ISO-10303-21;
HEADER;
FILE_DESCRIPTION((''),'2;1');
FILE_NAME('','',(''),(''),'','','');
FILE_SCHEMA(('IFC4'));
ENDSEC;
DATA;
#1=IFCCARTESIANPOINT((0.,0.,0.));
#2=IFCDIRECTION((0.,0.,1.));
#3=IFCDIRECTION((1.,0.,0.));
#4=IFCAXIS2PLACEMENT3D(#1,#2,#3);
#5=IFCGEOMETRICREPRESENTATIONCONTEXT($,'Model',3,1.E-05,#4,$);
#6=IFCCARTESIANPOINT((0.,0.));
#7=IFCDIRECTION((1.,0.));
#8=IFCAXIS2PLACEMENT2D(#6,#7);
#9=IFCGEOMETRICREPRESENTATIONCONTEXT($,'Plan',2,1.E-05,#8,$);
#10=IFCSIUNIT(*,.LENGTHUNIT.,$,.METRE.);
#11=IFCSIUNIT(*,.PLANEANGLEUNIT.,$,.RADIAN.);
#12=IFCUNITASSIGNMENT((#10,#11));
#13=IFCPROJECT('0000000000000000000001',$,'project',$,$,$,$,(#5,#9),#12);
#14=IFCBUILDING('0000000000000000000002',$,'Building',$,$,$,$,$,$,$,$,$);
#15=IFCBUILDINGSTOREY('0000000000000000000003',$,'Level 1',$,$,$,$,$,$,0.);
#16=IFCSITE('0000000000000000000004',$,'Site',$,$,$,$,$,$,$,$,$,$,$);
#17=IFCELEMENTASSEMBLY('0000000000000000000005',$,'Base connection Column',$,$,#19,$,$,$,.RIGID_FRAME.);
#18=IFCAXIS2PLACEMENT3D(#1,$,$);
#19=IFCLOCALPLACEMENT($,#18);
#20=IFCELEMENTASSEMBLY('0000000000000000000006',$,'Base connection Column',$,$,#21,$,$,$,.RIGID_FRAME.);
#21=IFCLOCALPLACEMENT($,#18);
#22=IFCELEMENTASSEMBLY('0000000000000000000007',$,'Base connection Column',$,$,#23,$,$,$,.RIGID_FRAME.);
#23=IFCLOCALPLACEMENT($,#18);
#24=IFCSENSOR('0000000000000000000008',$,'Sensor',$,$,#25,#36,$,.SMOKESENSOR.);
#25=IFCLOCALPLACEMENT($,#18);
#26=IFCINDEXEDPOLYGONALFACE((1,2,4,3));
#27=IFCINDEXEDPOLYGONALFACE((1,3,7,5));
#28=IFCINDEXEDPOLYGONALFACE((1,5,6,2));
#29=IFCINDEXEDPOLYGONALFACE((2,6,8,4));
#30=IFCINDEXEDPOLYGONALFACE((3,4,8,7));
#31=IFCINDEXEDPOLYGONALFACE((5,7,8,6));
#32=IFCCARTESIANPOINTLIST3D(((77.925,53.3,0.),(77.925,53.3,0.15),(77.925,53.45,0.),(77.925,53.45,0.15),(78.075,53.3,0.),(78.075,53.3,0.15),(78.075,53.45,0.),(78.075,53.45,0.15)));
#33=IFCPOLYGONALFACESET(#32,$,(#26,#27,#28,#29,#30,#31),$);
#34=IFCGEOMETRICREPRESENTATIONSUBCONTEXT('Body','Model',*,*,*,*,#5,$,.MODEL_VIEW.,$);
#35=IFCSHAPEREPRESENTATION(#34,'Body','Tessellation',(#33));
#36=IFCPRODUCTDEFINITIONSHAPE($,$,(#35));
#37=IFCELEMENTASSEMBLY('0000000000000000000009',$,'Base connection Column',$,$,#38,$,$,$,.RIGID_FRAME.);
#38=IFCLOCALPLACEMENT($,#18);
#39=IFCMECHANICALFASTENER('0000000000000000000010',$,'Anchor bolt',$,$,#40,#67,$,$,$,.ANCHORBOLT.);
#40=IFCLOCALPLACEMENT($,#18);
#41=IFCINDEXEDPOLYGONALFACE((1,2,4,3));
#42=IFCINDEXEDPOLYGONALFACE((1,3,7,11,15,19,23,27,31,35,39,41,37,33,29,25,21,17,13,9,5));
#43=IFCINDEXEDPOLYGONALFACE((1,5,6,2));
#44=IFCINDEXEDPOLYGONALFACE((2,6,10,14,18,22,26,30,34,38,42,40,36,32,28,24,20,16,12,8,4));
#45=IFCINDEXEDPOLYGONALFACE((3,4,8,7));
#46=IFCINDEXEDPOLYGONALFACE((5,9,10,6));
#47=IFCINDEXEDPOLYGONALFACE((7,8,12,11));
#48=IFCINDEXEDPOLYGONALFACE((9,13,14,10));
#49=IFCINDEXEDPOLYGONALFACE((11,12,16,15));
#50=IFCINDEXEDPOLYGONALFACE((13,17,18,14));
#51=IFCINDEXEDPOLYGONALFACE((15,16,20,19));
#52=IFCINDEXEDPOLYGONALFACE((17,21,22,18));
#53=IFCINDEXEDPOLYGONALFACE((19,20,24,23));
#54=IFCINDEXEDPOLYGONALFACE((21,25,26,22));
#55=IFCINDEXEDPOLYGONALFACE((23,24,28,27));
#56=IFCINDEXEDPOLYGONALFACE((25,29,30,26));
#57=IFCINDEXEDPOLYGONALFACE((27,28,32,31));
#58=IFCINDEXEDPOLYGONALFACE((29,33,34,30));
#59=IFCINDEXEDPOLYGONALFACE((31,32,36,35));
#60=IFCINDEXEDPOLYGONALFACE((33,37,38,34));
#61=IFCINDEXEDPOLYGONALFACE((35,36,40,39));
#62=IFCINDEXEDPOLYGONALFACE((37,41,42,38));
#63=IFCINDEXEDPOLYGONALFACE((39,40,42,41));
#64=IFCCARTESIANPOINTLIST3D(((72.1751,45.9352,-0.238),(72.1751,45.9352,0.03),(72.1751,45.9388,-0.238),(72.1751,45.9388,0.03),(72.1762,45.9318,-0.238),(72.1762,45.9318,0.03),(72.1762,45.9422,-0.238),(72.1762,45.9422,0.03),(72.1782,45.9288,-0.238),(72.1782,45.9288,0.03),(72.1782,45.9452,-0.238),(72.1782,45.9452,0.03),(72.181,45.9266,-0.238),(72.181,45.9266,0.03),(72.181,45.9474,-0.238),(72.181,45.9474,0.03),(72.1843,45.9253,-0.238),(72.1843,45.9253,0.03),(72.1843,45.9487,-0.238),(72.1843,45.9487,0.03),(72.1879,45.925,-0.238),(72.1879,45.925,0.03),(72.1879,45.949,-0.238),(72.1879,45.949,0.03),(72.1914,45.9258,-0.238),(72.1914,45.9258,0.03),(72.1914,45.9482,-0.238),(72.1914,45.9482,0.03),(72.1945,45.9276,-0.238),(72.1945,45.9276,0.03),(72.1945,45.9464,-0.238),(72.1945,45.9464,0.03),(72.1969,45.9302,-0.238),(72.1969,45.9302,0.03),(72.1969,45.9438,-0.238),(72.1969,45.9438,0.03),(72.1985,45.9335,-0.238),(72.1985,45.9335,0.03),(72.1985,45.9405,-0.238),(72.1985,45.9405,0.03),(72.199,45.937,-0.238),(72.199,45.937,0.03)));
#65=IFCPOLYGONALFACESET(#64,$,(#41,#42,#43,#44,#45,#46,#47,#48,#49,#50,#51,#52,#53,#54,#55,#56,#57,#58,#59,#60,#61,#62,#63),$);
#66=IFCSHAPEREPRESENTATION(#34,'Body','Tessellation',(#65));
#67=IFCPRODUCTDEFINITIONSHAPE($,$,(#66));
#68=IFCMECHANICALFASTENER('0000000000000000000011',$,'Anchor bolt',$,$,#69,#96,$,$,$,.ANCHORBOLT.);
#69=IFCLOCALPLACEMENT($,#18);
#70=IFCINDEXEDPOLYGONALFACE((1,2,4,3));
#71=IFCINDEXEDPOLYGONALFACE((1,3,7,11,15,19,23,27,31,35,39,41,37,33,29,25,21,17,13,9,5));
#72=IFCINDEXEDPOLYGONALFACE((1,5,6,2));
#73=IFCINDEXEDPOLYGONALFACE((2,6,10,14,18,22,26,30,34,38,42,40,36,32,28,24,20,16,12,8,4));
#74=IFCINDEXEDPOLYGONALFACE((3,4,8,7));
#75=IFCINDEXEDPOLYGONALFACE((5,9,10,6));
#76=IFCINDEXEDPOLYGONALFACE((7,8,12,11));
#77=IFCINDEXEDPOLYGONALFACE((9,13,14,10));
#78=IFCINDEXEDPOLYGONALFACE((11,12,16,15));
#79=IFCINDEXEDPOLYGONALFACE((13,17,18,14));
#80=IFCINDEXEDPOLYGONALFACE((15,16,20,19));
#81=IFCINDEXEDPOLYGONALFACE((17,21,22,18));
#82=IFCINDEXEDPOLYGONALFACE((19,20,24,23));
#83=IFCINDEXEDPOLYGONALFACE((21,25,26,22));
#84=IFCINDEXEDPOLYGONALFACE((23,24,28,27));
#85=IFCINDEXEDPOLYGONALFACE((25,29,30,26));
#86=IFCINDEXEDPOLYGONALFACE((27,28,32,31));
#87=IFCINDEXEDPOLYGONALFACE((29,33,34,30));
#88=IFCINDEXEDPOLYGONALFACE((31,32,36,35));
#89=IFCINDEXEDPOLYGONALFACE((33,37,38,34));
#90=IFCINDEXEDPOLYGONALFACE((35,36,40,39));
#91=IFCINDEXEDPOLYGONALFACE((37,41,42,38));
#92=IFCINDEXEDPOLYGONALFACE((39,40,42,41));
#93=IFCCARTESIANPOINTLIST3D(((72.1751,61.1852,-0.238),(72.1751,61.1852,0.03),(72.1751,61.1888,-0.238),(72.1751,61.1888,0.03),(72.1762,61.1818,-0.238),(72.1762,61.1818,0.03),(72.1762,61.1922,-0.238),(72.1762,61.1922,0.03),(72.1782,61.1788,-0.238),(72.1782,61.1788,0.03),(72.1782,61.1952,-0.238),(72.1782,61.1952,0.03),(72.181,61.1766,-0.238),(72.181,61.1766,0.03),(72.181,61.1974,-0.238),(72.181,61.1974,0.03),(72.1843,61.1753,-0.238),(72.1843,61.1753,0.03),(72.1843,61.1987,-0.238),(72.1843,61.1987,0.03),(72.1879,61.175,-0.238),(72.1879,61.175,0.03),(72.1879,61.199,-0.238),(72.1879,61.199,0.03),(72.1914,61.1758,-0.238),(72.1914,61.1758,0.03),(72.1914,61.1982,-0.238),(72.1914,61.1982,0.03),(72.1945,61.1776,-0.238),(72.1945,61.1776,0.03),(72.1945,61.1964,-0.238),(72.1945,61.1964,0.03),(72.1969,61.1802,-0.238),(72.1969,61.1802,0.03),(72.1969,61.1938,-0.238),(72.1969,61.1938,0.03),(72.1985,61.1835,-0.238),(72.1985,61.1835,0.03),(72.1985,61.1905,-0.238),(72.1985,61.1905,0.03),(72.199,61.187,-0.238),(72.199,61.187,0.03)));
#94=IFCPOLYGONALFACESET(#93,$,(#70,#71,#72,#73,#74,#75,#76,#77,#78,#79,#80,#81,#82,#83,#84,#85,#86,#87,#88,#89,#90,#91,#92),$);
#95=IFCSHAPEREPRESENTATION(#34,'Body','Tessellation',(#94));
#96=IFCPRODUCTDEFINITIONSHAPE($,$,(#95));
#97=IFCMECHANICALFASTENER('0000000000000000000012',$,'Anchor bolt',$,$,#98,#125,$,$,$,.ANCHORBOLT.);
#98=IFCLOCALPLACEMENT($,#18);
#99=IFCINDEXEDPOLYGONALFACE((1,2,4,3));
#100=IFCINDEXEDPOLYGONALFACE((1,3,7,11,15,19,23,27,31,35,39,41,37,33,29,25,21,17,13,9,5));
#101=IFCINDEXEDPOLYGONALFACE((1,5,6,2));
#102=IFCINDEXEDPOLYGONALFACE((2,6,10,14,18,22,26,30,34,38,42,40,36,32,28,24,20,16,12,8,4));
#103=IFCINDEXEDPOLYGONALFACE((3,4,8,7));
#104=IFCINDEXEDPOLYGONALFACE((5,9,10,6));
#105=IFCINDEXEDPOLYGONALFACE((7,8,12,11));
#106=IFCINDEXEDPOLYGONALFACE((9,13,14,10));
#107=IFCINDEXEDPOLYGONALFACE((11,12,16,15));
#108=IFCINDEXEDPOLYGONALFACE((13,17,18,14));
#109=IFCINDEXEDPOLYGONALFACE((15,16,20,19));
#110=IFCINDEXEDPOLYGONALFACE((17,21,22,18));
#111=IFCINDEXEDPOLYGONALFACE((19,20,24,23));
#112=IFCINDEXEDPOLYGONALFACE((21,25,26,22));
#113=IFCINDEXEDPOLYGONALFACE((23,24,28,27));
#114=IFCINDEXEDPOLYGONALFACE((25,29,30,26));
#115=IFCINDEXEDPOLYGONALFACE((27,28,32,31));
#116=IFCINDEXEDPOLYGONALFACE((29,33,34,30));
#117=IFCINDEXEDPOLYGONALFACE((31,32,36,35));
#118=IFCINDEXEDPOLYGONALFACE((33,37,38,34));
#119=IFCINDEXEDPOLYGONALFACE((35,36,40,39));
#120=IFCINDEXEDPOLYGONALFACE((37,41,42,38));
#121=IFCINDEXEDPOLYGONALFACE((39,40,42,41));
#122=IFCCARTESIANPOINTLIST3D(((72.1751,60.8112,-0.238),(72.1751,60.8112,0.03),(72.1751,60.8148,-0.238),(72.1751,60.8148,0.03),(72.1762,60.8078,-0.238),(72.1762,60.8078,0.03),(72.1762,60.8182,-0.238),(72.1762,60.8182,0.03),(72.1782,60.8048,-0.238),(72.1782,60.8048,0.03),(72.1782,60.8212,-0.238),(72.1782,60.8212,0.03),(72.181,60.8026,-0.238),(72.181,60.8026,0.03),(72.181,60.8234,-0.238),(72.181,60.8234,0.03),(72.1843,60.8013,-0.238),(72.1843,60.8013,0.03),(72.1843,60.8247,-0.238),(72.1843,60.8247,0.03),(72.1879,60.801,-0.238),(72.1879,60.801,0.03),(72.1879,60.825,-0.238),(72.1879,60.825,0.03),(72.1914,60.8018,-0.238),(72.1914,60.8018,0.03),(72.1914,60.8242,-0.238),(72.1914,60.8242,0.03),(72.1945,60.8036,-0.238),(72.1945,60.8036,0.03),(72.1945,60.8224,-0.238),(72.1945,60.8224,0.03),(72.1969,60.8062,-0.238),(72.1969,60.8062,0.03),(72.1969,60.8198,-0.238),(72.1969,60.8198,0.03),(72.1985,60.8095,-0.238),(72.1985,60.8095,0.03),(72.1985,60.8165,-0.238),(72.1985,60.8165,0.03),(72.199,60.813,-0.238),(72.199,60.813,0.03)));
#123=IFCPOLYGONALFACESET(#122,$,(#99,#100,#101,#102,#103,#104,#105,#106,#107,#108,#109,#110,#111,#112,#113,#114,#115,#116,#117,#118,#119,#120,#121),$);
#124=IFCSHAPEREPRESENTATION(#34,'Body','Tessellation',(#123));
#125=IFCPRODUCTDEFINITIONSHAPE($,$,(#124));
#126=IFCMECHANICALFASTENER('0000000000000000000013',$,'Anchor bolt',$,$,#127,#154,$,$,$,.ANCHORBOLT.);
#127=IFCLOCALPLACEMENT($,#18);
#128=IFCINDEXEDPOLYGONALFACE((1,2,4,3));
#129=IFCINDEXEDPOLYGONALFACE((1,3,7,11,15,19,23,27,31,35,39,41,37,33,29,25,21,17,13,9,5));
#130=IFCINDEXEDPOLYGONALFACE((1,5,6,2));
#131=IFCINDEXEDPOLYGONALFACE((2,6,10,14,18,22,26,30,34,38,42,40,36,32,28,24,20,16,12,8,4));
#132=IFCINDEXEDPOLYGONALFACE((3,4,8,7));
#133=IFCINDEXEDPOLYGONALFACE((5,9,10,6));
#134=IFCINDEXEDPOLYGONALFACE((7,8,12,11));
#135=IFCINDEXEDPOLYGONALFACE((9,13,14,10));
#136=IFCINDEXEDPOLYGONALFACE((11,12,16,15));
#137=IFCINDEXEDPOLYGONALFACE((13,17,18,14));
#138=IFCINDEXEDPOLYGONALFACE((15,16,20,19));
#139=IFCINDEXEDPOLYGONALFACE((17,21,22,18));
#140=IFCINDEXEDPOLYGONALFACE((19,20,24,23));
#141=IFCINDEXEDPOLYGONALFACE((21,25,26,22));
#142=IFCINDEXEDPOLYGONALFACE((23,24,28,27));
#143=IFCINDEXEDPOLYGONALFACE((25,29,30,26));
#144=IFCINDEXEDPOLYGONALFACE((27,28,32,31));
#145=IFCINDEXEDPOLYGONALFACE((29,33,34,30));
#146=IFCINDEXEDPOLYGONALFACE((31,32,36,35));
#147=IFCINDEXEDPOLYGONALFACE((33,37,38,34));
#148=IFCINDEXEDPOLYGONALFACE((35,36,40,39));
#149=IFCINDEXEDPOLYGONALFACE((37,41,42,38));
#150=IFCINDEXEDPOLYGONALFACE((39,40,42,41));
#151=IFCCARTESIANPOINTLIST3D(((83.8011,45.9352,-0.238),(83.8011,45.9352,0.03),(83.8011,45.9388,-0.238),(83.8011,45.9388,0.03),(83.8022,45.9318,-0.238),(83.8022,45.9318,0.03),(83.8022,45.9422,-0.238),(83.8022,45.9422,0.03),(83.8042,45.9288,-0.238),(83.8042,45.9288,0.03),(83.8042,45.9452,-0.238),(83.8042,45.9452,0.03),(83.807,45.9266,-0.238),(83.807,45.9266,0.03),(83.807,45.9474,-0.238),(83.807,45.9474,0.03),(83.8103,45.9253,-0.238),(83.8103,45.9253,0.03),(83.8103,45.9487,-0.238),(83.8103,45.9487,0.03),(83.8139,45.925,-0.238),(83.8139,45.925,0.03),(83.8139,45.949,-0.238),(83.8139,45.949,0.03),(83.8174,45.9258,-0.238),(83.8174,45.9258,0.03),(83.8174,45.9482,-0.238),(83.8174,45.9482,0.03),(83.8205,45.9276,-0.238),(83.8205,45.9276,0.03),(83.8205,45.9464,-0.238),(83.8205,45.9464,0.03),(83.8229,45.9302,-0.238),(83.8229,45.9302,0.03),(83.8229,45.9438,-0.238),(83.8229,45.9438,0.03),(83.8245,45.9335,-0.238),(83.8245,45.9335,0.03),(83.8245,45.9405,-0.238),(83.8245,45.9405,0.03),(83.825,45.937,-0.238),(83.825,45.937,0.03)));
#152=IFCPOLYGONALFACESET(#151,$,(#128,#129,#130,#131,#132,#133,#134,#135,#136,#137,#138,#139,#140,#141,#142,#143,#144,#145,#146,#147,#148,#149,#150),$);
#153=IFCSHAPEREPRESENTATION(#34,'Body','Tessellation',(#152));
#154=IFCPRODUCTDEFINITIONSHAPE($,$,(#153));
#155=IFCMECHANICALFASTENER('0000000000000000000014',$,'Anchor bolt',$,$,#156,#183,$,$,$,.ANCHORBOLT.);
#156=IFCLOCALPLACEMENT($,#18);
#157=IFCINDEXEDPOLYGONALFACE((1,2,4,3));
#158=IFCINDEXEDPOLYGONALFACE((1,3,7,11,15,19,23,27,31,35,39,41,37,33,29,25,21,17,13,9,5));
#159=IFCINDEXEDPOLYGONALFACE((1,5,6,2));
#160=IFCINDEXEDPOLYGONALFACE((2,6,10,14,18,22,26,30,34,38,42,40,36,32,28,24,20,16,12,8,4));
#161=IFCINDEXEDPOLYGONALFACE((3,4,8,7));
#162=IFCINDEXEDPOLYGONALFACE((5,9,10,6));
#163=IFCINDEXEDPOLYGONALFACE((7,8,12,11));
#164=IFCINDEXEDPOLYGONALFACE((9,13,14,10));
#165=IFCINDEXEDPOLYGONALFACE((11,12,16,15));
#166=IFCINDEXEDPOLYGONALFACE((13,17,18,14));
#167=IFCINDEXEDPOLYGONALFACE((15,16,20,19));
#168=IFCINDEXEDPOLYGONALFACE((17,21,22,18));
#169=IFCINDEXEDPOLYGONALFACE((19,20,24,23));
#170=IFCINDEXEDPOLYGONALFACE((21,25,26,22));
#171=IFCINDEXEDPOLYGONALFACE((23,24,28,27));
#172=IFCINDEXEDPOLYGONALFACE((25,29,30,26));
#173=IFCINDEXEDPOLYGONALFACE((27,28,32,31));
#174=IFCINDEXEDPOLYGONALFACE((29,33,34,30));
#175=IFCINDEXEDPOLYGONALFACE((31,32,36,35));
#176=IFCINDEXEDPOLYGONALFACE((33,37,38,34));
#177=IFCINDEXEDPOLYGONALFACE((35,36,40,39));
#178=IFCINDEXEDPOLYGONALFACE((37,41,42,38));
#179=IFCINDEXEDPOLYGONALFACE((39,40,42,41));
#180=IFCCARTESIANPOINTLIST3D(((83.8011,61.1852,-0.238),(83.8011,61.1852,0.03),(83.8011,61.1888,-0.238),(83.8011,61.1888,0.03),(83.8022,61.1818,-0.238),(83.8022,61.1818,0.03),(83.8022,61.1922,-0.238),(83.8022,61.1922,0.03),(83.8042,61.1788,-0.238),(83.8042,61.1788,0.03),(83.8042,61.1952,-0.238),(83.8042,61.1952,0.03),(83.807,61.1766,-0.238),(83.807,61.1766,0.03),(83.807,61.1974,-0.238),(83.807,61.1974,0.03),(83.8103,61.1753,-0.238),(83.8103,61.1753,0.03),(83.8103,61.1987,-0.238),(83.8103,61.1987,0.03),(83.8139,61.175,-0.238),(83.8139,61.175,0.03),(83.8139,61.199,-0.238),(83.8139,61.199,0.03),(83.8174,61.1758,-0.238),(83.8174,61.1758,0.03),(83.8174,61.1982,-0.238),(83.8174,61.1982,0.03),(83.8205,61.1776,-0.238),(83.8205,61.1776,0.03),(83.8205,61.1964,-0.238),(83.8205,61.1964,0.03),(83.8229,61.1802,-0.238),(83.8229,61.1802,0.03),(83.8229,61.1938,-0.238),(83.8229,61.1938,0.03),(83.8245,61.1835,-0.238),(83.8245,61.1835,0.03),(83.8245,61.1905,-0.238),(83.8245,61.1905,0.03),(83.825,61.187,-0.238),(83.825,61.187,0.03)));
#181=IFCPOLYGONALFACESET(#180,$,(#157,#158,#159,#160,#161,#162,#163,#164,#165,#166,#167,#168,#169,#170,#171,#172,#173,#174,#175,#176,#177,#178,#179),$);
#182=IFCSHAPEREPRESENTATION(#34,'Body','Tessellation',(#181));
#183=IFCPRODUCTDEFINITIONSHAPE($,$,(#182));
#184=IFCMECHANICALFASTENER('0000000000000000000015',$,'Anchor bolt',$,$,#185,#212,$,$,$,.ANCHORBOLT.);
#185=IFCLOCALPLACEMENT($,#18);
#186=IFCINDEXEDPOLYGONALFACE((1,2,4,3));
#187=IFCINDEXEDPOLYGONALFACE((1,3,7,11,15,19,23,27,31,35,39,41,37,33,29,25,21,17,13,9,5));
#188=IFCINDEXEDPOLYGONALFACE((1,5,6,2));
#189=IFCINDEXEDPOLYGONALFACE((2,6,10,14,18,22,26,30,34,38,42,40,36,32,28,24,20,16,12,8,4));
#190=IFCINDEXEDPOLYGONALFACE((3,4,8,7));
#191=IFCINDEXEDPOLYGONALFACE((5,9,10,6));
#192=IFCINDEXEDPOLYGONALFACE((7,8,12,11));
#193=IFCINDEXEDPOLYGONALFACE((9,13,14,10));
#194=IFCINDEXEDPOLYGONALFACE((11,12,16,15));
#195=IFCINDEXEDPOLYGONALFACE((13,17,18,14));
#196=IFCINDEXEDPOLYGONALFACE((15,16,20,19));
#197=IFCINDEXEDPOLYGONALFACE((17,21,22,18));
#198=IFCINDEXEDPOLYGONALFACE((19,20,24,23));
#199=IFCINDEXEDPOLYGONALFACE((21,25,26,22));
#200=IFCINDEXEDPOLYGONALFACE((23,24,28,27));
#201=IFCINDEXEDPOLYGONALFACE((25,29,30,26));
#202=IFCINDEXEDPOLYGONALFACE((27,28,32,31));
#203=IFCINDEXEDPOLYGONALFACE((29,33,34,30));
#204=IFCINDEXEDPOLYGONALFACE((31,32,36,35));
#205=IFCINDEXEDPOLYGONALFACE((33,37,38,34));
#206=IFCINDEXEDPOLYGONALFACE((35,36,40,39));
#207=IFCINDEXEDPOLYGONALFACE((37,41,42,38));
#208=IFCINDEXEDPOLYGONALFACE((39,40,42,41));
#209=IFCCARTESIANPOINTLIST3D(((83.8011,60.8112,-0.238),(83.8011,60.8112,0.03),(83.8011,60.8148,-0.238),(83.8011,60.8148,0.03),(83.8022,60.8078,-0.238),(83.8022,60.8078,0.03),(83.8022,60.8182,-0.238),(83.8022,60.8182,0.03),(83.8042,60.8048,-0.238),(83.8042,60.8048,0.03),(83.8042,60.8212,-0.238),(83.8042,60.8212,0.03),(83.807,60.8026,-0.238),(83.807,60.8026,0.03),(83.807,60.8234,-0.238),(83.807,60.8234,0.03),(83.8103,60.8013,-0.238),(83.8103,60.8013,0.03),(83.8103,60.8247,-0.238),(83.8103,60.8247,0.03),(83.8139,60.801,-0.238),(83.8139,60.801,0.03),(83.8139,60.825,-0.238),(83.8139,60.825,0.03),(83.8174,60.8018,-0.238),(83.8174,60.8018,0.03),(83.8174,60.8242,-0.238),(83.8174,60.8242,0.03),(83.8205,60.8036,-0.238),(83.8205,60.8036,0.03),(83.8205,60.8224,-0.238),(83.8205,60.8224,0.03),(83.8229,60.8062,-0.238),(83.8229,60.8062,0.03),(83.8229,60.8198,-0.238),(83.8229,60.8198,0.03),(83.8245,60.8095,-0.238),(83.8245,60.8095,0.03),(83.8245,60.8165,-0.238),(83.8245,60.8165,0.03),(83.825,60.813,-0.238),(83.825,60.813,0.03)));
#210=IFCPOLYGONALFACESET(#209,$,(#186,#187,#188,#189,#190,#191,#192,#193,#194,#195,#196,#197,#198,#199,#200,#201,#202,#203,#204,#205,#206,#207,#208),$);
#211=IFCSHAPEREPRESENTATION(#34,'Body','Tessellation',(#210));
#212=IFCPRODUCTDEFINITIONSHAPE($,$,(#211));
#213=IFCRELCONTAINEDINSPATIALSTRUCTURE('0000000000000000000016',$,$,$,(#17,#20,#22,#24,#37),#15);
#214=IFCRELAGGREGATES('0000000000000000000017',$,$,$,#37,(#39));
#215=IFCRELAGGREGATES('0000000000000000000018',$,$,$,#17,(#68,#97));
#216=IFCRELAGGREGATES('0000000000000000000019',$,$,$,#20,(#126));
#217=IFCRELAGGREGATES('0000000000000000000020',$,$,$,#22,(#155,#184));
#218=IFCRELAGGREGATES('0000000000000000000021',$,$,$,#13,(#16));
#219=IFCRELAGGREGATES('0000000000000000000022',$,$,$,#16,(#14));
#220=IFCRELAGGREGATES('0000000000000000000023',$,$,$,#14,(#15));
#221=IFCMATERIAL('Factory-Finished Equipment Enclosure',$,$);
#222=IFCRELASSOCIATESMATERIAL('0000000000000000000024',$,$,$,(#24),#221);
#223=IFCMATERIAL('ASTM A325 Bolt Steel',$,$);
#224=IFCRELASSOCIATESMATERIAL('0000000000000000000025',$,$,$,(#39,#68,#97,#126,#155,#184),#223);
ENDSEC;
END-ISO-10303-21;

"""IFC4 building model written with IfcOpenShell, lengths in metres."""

from ifc_helpers import new_model, si_unit, frame, origin_with_axes, origin_2d, origin_2d_with_axis, place, context, subcontext, project, spatial, rectangle, circle, extrude, material, element, aggregate, save


model = new_model("IFC4")

# Units and contexts
model_context = context("Model", 3, precision=1e-05, world=origin_with_axes())
plan_context = context("Plan", 2, precision=1e-05, world=origin_2d_with_axis())
body_context = subcontext(model_context, "Body", "Model", "MODEL_VIEW")
ifc_project = project(units=[si_unit("LENGTHUNIT", "METRE"), si_unit("PLANEANGLEUNIT", "RADIAN")], contexts=[model_context, plan_context])

# Site, building, storey
site = spatial("IfcSite", under=ifc_project, Name="Site")
building = spatial("IfcBuilding", under=site, Name="Building")
storey = spatial("IfcBuildingStorey", under=building, Name="Level 1", Elevation=0.0)

# Element assemblies
assembly_1 = element("IfcElementAssembly", 1, inside=storey, Name="Base connection Column", PredefinedType="RIGID_FRAME")
assembly_2 = element("IfcElementAssembly", 2, inside=storey, Name="Base connection Column", PredefinedType="RIGID_FRAME")
assembly_3 = element("IfcElementAssembly", 3, inside=storey, Name="Base connection Column", PredefinedType="RIGID_FRAME")

# Shared definitions
ifc_material_1 = material(Name="Factory-Finished Equipment Enclosure")

# Sensor
sensor_placement = place(None, frame((78.0, 53.375, 0.0), z_axis=(0.0, 0.0, 1.0), x_axis=(1.0, 0.0, 0.0)))
element("IfcSensor", 4, at=sensor_placement, inside=storey, material=ifc_material_1, Name="Sensor", PredefinedType="SMOKESENSOR", context=body_context, shape_type="SweptSolid", body=[
    extrude(rectangle(XDim=0.15, YDim=0.15, at=origin_2d_with_axis()), origin_with_axes(), (0.0, 0.0, 1.0), 0.15),
])

# Element assembly, mechanical fastener
assembly_4 = element("IfcElementAssembly", 5, inside=storey, Name="Base connection Column", PredefinedType="RIGID_FRAME")
ifc_material_2 = material(Name="ASTM A325 Bolt Steel")
mechanical_fastener_1_placement = place(None, frame((72.187, 45.937, -0.238), z_axis=(0.0, 0.0, 1.0), x_axis=(1.0, 0.0, 0.0)))
mechanical_fastener_1 = element("IfcMechanicalFastener", 6, at=mechanical_fastener_1_placement, material=ifc_material_2, Name="Anchor bolt", PredefinedType="ANCHORBOLT", context=body_context, shape_type="SweptSolid", body=[
    extrude(circle(Radius=0.012, at=origin_2d()), origin_with_axes(), (0.0, 0.0, 1.0), 0.268),
])
aggregate(assembly_4, [mechanical_fastener_1])

# Mechanical fasteners
mechanical_fastener_2_placement = place(None, frame((72.187, 61.187, -0.238), z_axis=(0.0, 0.0, 1.0), x_axis=(1.0, 0.0, 0.0)))
mechanical_fastener_2 = element("IfcMechanicalFastener", 7, at=mechanical_fastener_2_placement, material=ifc_material_2, Name="Anchor bolt", PredefinedType="ANCHORBOLT", context=body_context, shape_type="SweptSolid", body=[
    extrude(circle(Radius=0.012, at=origin_2d()), origin_with_axes(), (0.0, 0.0, 1.0), 0.268),
])
mechanical_fastener_3_placement = place(None, frame((72.187, 60.813, -0.238), z_axis=(0.0, 0.0, 1.0), x_axis=(1.0, 0.0, 0.0)))
mechanical_fastener_3 = element("IfcMechanicalFastener", 8, at=mechanical_fastener_3_placement, material=ifc_material_2, Name="Anchor bolt", PredefinedType="ANCHORBOLT", context=body_context, shape_type="SweptSolid", body=[
    extrude(circle(Radius=0.012, at=origin_2d()), origin_with_axes(), (0.0, 0.0, 1.0), 0.268),
])
aggregate(assembly_1, [mechanical_fastener_2, mechanical_fastener_3])
mechanical_fastener_4_placement = place(None, frame((83.813, 45.937, -0.238), z_axis=(0.0, 0.0, 1.0), x_axis=(1.0, 0.0, 0.0)))
mechanical_fastener_4 = element("IfcMechanicalFastener", 9, at=mechanical_fastener_4_placement, material=ifc_material_2, Name="Anchor bolt", PredefinedType="ANCHORBOLT", context=body_context, shape_type="SweptSolid", body=[
    extrude(circle(Radius=0.012, at=origin_2d()), origin_with_axes(), (0.0, 0.0, 1.0), 0.268),
])
aggregate(assembly_2, [mechanical_fastener_4])
mechanical_fastener_5_placement = place(None, frame((83.813, 61.187, -0.238), z_axis=(0.0, 0.0, 1.0), x_axis=(1.0, 0.0, 0.0)))
mechanical_fastener_5 = element("IfcMechanicalFastener", 10, at=mechanical_fastener_5_placement, material=ifc_material_2, Name="Anchor bolt", PredefinedType="ANCHORBOLT", context=body_context, shape_type="SweptSolid", body=[
    extrude(circle(Radius=0.012, at=origin_2d()), origin_with_axes(), (0.0, 0.0, 1.0), 0.268),
])
mechanical_fastener_6_placement = place(None, frame((83.813, 60.813, -0.238), z_axis=(0.0, 0.0, 1.0), x_axis=(1.0, 0.0, 0.0)))
mechanical_fastener_6 = element("IfcMechanicalFastener", 11, at=mechanical_fastener_6_placement, material=ifc_material_2, Name="Anchor bolt", PredefinedType="ANCHORBOLT", context=body_context, shape_type="SweptSolid", body=[
    extrude(circle(Radius=0.012, at=origin_2d()), origin_with_axes(), (0.0, 0.0, 1.0), 0.268),
])
aggregate(assembly_3, [mechanical_fastener_5, mechanical_fastener_6])

save(model, "model.ifc")
